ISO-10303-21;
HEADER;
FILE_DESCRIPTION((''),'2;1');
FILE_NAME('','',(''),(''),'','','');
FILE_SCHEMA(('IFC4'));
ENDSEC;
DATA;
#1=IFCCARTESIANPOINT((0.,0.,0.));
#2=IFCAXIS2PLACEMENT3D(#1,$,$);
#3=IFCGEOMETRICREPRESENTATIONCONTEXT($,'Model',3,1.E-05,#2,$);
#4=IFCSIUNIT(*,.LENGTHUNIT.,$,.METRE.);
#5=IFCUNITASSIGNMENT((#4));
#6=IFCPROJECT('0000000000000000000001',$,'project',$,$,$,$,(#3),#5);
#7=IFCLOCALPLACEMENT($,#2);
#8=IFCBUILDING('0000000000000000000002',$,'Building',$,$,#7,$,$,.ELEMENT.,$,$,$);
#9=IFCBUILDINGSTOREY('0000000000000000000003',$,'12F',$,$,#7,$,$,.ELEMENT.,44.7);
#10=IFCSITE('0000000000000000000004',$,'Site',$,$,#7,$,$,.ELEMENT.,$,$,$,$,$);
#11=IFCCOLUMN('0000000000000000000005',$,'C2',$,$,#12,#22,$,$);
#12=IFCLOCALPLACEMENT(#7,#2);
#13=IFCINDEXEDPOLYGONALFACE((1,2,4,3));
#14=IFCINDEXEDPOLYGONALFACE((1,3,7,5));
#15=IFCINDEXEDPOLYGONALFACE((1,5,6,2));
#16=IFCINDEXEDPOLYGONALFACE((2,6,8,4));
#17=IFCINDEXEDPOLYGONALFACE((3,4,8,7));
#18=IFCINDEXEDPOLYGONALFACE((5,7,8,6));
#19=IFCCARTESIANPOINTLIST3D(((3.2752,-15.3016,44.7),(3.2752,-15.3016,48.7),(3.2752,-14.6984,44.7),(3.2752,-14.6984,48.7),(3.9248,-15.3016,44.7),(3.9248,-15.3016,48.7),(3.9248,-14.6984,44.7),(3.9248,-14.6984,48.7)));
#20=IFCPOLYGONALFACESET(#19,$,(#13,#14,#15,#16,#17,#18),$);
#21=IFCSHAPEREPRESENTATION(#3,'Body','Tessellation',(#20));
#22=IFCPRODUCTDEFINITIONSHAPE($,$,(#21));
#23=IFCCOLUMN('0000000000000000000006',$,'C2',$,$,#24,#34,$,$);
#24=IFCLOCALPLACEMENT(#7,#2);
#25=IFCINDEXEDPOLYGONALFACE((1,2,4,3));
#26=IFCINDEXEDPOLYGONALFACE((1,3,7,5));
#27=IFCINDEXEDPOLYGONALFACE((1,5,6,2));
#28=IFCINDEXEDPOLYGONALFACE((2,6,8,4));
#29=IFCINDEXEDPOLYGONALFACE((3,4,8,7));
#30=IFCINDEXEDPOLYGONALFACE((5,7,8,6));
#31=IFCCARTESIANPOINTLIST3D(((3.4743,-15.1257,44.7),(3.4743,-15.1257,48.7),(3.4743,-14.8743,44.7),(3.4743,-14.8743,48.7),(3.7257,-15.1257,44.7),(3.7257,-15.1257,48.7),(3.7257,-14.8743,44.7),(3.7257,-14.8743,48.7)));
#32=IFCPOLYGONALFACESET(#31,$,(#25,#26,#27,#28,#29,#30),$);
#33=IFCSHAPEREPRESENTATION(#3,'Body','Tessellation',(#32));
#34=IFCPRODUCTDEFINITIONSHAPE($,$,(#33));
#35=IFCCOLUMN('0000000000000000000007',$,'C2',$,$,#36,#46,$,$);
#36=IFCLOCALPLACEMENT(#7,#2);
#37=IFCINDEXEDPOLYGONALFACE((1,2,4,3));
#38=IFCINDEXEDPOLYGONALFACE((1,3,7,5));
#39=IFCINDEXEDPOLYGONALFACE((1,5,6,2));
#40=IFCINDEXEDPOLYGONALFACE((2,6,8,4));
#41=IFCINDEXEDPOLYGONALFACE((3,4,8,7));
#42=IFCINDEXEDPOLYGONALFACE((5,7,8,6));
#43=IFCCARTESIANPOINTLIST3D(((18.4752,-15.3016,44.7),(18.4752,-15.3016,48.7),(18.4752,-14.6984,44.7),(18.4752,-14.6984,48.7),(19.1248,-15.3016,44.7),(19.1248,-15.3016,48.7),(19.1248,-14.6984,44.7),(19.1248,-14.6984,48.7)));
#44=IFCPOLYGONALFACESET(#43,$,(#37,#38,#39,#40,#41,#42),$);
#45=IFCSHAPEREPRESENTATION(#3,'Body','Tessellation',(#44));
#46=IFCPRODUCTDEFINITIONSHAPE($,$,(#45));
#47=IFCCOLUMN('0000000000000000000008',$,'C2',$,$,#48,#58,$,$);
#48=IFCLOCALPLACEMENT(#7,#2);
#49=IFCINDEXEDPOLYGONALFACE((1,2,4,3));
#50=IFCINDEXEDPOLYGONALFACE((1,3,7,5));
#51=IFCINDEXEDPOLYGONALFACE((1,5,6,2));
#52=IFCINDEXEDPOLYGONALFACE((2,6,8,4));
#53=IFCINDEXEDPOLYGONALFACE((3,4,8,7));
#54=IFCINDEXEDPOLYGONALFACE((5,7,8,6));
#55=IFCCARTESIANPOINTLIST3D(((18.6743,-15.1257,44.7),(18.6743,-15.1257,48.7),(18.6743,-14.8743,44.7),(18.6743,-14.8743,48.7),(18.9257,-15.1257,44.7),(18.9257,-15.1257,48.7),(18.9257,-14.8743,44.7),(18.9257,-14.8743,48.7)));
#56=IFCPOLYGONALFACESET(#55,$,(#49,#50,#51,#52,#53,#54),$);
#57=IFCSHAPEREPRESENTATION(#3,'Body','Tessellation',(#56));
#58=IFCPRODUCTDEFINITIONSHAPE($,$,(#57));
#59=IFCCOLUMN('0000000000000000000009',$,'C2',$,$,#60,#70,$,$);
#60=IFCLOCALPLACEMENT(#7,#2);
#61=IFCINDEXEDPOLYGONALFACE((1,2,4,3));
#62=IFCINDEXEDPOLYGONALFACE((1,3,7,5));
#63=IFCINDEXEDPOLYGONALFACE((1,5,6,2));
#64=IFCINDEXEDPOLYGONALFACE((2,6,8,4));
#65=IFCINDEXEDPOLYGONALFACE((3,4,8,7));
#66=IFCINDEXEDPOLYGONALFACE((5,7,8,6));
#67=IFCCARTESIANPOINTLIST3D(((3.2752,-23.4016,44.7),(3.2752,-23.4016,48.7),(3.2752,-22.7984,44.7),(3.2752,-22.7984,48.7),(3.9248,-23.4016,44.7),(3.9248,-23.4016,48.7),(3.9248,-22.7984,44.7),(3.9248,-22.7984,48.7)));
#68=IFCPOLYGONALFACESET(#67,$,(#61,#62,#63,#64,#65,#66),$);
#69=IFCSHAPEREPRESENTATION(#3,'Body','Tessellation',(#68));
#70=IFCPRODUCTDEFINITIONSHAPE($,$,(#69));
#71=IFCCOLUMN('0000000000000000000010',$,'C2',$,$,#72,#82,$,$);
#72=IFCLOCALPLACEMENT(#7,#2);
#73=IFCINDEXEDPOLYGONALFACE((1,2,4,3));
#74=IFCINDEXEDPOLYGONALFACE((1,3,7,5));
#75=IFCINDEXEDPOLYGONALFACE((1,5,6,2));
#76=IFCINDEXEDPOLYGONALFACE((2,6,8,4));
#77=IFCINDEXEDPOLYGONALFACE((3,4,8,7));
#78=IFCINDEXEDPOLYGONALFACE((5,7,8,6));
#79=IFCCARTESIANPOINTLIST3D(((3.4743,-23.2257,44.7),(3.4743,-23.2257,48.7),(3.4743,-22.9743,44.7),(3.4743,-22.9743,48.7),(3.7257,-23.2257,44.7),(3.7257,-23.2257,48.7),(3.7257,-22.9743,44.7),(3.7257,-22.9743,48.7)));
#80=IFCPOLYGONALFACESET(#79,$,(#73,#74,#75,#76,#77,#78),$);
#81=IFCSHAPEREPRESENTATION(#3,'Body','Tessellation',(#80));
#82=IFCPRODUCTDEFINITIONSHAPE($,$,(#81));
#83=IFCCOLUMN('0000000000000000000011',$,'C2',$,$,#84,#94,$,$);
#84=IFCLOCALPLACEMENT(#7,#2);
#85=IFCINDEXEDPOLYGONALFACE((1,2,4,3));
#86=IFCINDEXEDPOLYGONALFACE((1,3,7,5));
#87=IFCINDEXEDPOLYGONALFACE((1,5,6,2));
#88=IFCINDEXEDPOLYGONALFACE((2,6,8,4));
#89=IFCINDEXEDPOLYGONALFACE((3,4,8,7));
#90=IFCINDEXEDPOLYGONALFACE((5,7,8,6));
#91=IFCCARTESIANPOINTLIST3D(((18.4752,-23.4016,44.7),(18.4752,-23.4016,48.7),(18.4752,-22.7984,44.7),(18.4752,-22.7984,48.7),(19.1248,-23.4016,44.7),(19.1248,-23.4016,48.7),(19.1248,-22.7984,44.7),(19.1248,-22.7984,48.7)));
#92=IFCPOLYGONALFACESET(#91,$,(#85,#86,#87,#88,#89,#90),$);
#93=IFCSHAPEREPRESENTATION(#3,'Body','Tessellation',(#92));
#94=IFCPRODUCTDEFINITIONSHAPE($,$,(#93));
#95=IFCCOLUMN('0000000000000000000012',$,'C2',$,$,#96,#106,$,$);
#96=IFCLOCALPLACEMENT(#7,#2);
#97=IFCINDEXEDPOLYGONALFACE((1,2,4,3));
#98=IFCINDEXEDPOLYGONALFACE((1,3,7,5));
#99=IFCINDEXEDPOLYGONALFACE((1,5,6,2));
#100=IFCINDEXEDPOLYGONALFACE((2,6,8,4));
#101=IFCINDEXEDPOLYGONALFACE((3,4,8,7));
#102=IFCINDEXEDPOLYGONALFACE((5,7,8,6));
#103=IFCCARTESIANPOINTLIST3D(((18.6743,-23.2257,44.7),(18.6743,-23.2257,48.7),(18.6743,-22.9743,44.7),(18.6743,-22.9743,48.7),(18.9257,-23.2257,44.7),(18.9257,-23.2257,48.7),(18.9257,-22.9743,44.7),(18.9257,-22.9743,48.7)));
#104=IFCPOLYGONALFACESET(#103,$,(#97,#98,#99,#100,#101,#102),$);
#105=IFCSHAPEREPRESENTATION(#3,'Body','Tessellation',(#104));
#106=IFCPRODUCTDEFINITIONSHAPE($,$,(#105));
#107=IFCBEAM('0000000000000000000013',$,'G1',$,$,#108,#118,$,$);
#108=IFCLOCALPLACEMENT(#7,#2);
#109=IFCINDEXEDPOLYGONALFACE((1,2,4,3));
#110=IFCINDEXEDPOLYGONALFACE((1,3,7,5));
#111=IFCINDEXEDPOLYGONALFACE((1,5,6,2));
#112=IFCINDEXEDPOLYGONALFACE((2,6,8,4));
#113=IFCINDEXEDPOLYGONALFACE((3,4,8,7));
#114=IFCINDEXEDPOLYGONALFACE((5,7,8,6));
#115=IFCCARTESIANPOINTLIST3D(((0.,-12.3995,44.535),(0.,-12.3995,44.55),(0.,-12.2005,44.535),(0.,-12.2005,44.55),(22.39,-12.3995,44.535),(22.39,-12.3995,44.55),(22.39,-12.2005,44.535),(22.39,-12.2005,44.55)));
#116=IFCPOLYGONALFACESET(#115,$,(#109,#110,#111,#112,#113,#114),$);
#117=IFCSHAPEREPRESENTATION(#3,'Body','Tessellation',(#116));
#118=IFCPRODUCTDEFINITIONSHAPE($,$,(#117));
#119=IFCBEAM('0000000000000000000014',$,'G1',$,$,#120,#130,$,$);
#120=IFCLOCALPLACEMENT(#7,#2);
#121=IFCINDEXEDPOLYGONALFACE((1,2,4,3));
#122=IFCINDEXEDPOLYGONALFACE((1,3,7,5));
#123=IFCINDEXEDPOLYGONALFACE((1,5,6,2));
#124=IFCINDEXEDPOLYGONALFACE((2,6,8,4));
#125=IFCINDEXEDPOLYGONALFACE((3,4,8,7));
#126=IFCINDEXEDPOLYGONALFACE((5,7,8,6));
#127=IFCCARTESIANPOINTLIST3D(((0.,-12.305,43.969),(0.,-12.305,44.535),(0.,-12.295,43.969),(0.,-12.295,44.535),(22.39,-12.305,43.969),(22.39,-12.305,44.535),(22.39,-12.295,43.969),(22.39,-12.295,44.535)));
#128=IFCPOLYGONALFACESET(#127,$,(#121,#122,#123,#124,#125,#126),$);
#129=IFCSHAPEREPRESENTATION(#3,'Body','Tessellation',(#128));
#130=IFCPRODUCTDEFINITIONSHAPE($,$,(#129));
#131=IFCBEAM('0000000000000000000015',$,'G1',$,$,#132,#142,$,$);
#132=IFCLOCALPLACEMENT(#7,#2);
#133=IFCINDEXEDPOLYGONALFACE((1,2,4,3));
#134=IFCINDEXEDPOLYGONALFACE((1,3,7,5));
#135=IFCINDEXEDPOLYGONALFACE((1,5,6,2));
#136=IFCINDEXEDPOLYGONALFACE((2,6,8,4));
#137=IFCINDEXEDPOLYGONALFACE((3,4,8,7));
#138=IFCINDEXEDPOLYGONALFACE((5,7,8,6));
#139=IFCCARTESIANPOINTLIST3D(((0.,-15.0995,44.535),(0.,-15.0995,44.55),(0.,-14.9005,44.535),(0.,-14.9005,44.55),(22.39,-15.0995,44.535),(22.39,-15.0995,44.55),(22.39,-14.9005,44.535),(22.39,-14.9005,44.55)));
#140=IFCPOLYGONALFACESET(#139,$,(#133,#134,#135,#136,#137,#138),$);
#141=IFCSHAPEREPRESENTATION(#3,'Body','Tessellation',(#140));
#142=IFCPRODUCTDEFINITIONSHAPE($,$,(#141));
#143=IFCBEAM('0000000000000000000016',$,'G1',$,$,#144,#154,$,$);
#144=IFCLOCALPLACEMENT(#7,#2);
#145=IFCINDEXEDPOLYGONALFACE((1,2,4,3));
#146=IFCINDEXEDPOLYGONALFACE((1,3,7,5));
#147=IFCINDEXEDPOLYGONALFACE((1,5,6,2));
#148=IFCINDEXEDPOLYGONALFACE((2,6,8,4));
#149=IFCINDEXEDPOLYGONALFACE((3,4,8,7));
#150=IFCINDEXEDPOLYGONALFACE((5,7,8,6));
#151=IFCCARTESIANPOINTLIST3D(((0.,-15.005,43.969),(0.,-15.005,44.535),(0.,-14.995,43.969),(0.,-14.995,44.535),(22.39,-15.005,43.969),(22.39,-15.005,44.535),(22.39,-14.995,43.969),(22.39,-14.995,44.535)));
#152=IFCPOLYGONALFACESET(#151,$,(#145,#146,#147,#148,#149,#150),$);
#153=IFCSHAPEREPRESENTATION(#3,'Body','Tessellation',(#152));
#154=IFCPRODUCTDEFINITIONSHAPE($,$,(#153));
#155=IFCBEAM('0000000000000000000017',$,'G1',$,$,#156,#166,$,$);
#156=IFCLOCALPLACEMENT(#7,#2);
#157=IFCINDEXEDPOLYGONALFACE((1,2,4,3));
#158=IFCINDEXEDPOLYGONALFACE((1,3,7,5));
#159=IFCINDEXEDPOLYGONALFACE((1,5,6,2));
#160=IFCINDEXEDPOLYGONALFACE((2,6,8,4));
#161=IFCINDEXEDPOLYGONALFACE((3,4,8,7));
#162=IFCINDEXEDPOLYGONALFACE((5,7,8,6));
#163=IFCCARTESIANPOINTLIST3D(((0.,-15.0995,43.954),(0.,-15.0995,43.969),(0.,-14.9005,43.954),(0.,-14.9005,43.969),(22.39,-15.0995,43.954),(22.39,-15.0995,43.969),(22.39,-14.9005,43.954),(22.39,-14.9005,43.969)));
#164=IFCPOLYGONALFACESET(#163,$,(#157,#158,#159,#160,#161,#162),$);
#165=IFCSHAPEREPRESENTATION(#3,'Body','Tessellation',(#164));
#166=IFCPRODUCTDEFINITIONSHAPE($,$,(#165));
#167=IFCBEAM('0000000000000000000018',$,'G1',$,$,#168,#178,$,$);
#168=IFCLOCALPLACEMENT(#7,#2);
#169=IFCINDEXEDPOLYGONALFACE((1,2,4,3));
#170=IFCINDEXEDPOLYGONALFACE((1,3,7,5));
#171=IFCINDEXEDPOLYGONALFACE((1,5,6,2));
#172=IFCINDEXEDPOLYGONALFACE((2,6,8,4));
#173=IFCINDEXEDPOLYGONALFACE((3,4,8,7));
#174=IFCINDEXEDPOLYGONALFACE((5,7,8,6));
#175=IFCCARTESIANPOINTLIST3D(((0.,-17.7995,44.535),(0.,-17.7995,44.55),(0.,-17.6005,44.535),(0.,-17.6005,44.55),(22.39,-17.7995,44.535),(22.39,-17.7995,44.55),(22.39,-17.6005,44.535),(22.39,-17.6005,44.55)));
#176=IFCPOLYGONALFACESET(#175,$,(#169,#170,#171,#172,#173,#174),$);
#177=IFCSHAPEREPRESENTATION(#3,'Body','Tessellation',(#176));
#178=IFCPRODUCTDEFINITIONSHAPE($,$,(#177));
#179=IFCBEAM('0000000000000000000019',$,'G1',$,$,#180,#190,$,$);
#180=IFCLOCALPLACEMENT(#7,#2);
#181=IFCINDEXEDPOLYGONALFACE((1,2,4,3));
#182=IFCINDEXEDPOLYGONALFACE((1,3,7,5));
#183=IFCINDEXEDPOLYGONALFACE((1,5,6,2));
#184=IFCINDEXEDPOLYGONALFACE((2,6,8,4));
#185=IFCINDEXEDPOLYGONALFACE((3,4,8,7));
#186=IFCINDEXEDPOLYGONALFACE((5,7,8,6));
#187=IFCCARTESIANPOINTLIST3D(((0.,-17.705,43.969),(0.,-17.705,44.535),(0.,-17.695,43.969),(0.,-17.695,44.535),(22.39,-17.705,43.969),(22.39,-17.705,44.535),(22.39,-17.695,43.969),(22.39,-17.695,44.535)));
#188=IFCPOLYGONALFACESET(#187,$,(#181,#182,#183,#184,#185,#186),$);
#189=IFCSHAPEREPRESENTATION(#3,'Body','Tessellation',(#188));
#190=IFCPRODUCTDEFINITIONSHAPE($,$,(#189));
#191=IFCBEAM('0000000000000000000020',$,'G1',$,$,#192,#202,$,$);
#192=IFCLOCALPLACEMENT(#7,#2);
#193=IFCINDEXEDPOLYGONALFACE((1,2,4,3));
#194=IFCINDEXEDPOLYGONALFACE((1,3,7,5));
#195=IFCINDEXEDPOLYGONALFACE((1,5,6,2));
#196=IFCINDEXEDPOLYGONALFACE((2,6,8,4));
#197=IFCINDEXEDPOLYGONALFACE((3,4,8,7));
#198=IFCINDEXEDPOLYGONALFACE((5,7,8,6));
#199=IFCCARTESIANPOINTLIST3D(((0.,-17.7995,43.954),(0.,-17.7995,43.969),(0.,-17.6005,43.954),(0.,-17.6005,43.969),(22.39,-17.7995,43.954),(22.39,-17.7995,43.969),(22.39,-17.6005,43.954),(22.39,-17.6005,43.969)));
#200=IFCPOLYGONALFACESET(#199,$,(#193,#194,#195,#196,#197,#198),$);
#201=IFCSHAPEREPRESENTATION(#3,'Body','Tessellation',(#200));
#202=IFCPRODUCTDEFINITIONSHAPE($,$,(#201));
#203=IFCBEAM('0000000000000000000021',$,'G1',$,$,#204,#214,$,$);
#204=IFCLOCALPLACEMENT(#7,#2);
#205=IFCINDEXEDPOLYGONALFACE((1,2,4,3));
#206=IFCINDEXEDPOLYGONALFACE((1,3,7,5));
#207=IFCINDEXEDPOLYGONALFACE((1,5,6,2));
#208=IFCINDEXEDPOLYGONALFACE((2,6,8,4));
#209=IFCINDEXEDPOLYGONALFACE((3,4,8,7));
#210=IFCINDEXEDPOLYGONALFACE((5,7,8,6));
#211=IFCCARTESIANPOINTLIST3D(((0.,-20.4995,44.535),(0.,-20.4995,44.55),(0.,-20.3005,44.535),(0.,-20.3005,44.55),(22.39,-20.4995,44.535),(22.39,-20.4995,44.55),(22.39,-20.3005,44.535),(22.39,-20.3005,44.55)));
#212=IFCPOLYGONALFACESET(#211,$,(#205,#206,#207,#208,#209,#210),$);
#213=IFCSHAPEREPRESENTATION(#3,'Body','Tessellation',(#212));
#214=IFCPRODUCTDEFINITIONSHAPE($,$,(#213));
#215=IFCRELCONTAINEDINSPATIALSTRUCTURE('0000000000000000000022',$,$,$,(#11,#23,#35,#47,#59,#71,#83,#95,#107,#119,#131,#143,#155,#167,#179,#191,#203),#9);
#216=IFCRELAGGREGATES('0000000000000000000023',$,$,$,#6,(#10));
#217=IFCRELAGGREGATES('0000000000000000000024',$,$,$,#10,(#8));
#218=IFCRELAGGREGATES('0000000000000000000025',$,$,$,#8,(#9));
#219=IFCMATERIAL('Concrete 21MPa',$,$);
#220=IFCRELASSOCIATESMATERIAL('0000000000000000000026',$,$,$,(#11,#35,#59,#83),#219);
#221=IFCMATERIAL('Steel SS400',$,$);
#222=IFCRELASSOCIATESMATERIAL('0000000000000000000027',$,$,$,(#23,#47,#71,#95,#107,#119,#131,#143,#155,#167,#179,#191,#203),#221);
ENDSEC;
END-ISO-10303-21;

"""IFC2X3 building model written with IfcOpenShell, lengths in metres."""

from ifc_helpers import new_model, si_unit, frame, origin, origin_2d, place, context, project, spatial, rectangle, extrude, material, element, save


model = new_model("IFC2X3")

# Units and contexts
model_context = context("Model", 3, precision=1e-05, world=origin())
ifc_project = project(units=[si_unit("LENGTHUNIT", "METRE")], contexts=[model_context])

# Site, building, storey
placement = place(None, origin())
site = spatial("IfcSite", under=ifc_project, at=placement, Name="Site", CompositionType="ELEMENT")
building = spatial("IfcBuilding", under=site, at=placement, Name="Building", CompositionType="ELEMENT")
storey = spatial("IfcBuildingStorey", under=building, at=placement, Name="12F", CompositionType="ELEMENT", Elevation=44.7)

# Columns
ifc_material_1 = material(Name="Concrete 21MPa")
column_1_placement = place(None, frame((3.6, -15.0, 44.7)))
element("IfcColumn", 1, at=column_1_placement, inside=storey, material=ifc_material_1, Name="C2", context=model_context, shape_type="SweptSolid", body=[
    extrude(rectangle(XDim=0.6496, YDim=0.6032, at=origin_2d()), origin(), (0.0, 0.0, 1.0), 4.0),
])
ifc_material_2 = material(Name="Steel SS400")
column_2_placement = place(None, frame((3.6, -15.0, 44.7)))
element("IfcColumn", 2, at=column_2_placement, inside=storey, material=ifc_material_2, Name="C2", context=model_context, shape_type="SweptSolid", body=[
    extrude(rectangle(XDim=0.2513, YDim=0.2513, at=origin_2d()), origin(), (0.0, 0.0, 1.0), 4.0),
])
column_3_placement = place(None, frame((18.8, -15.0, 44.7)))
element("IfcColumn", 3, at=column_3_placement, inside=storey, material=ifc_material_1, Name="C2", context=model_context, shape_type="SweptSolid", body=[
    extrude(rectangle(XDim=0.6496, YDim=0.6032, at=origin_2d()), origin(), (0.0, 0.0, 1.0), 4.0),
])
column_4_placement = place(None, frame((18.8, -15.0, 44.7)))
element("IfcColumn", 4, at=column_4_placement, inside=storey, material=ifc_material_2, Name="C2", context=model_context, shape_type="SweptSolid", body=[
    extrude(rectangle(XDim=0.2513, YDim=0.2513, at=origin_2d()), origin(), (0.0, 0.0, 1.0), 4.0),
])
column_5_placement = place(None, frame((3.6, -23.1, 44.7)))
element("IfcColumn", 5, at=column_5_placement, inside=storey, material=ifc_material_1, Name="C2", context=model_context, shape_type="SweptSolid", body=[
    extrude(rectangle(XDim=0.6496, YDim=0.6032, at=origin_2d()), origin(), (0.0, 0.0, 1.0), 4.0),
])
column_6_placement = place(None, frame((3.6, -23.1, 44.7)))
element("IfcColumn", 6, at=column_6_placement, inside=storey, material=ifc_material_2, Name="C2", context=model_context, shape_type="SweptSolid", body=[
    extrude(rectangle(XDim=0.2513, YDim=0.2513, at=origin_2d()), origin(), (0.0, 0.0, 1.0), 4.0),
])
column_7_placement = place(None, frame((18.8, -23.1, 44.7)))
element("IfcColumn", 7, at=column_7_placement, inside=storey, material=ifc_material_1, Name="C2", context=model_context, shape_type="SweptSolid", body=[
    extrude(rectangle(XDim=0.6496, YDim=0.6032, at=origin_2d()), origin(), (0.0, 0.0, 1.0), 4.0),
])
column_8_placement = place(None, frame((18.8, -23.1, 44.7)))
element("IfcColumn", 8, at=column_8_placement, inside=storey, material=ifc_material_2, Name="C2", context=model_context, shape_type="SweptSolid", body=[
    extrude(rectangle(XDim=0.2513, YDim=0.2513, at=origin_2d()), origin(), (0.0, 0.0, 1.0), 4.0),
])

# Beams
beam_1_placement = place(None, frame((11.195, -12.3, 44.535)))
element("IfcBeam", 9, at=beam_1_placement, inside=storey, material=ifc_material_2, Name="G1", context=model_context, shape_type="SweptSolid", body=[
    extrude(rectangle(XDim=22.39, YDim=0.199, at=origin_2d()), origin(), (0.0, 0.0, 1.0), 0.015),
])
beam_2_placement = place(None, frame((11.195, -12.3, 43.969)))
element("IfcBeam", 10, at=beam_2_placement, inside=storey, material=ifc_material_2, Name="G1", context=model_context, shape_type="SweptSolid", body=[
    extrude(rectangle(XDim=22.39, YDim=0.01, at=origin_2d()), origin(), (0.0, 0.0, 1.0), 0.566),
])
beam_3_placement = place(None, frame((11.195, -15.0, 44.535)))
element("IfcBeam", 11, at=beam_3_placement, inside=storey, material=ifc_material_2, Name="G1", context=model_context, shape_type="SweptSolid", body=[
    extrude(rectangle(XDim=22.39, YDim=0.199, at=origin_2d()), origin(), (0.0, 0.0, 1.0), 0.015),
])
beam_4_placement = place(None, frame((11.195, -15.0, 43.969)))
element("IfcBeam", 12, at=beam_4_placement, inside=storey, material=ifc_material_2, Name="G1", context=model_context, shape_type="SweptSolid", body=[
    extrude(rectangle(XDim=22.39, YDim=0.01, at=origin_2d()), origin(), (0.0, 0.0, 1.0), 0.566),
])
for number, where, name in (
    (13, (11.195, -15.0, 43.954), "G1"),
    (14, (11.195, -17.7, 44.535), "G1"),
):
    element("IfcBeam", number, at=place(None, frame(where)), inside=storey, material=ifc_material_2, Name=name, context=model_context, shape_type="SweptSolid", body=[
        extrude(rectangle(XDim=22.39, YDim=0.199, at=origin_2d()), origin(), (0.0, 0.0, 1.0), 0.015),
    ])
beam_5_placement = place(None, frame((11.195, -17.7, 43.969)))
element("IfcBeam", 15, at=beam_5_placement, inside=storey, material=ifc_material_2, Name="G1", context=model_context, shape_type="SweptSolid", body=[
    extrude(rectangle(XDim=22.39, YDim=0.01, at=origin_2d()), origin(), (0.0, 0.0, 1.0), 0.566),
])
for number, where, name in (
    (16, (11.195, -17.7, 43.954), "G1"),
    (17, (11.195, -20.4, 44.535), "G1"),
):
    element("IfcBeam", number, at=place(None, frame(where)), inside=storey, material=ifc_material_2, Name=name, context=model_context, shape_type="SweptSolid", body=[
        extrude(rectangle(XDim=22.39, YDim=0.199, at=origin_2d()), origin(), (0.0, 0.0, 1.0), 0.015),
    ])

save(model, "model.ifc")
